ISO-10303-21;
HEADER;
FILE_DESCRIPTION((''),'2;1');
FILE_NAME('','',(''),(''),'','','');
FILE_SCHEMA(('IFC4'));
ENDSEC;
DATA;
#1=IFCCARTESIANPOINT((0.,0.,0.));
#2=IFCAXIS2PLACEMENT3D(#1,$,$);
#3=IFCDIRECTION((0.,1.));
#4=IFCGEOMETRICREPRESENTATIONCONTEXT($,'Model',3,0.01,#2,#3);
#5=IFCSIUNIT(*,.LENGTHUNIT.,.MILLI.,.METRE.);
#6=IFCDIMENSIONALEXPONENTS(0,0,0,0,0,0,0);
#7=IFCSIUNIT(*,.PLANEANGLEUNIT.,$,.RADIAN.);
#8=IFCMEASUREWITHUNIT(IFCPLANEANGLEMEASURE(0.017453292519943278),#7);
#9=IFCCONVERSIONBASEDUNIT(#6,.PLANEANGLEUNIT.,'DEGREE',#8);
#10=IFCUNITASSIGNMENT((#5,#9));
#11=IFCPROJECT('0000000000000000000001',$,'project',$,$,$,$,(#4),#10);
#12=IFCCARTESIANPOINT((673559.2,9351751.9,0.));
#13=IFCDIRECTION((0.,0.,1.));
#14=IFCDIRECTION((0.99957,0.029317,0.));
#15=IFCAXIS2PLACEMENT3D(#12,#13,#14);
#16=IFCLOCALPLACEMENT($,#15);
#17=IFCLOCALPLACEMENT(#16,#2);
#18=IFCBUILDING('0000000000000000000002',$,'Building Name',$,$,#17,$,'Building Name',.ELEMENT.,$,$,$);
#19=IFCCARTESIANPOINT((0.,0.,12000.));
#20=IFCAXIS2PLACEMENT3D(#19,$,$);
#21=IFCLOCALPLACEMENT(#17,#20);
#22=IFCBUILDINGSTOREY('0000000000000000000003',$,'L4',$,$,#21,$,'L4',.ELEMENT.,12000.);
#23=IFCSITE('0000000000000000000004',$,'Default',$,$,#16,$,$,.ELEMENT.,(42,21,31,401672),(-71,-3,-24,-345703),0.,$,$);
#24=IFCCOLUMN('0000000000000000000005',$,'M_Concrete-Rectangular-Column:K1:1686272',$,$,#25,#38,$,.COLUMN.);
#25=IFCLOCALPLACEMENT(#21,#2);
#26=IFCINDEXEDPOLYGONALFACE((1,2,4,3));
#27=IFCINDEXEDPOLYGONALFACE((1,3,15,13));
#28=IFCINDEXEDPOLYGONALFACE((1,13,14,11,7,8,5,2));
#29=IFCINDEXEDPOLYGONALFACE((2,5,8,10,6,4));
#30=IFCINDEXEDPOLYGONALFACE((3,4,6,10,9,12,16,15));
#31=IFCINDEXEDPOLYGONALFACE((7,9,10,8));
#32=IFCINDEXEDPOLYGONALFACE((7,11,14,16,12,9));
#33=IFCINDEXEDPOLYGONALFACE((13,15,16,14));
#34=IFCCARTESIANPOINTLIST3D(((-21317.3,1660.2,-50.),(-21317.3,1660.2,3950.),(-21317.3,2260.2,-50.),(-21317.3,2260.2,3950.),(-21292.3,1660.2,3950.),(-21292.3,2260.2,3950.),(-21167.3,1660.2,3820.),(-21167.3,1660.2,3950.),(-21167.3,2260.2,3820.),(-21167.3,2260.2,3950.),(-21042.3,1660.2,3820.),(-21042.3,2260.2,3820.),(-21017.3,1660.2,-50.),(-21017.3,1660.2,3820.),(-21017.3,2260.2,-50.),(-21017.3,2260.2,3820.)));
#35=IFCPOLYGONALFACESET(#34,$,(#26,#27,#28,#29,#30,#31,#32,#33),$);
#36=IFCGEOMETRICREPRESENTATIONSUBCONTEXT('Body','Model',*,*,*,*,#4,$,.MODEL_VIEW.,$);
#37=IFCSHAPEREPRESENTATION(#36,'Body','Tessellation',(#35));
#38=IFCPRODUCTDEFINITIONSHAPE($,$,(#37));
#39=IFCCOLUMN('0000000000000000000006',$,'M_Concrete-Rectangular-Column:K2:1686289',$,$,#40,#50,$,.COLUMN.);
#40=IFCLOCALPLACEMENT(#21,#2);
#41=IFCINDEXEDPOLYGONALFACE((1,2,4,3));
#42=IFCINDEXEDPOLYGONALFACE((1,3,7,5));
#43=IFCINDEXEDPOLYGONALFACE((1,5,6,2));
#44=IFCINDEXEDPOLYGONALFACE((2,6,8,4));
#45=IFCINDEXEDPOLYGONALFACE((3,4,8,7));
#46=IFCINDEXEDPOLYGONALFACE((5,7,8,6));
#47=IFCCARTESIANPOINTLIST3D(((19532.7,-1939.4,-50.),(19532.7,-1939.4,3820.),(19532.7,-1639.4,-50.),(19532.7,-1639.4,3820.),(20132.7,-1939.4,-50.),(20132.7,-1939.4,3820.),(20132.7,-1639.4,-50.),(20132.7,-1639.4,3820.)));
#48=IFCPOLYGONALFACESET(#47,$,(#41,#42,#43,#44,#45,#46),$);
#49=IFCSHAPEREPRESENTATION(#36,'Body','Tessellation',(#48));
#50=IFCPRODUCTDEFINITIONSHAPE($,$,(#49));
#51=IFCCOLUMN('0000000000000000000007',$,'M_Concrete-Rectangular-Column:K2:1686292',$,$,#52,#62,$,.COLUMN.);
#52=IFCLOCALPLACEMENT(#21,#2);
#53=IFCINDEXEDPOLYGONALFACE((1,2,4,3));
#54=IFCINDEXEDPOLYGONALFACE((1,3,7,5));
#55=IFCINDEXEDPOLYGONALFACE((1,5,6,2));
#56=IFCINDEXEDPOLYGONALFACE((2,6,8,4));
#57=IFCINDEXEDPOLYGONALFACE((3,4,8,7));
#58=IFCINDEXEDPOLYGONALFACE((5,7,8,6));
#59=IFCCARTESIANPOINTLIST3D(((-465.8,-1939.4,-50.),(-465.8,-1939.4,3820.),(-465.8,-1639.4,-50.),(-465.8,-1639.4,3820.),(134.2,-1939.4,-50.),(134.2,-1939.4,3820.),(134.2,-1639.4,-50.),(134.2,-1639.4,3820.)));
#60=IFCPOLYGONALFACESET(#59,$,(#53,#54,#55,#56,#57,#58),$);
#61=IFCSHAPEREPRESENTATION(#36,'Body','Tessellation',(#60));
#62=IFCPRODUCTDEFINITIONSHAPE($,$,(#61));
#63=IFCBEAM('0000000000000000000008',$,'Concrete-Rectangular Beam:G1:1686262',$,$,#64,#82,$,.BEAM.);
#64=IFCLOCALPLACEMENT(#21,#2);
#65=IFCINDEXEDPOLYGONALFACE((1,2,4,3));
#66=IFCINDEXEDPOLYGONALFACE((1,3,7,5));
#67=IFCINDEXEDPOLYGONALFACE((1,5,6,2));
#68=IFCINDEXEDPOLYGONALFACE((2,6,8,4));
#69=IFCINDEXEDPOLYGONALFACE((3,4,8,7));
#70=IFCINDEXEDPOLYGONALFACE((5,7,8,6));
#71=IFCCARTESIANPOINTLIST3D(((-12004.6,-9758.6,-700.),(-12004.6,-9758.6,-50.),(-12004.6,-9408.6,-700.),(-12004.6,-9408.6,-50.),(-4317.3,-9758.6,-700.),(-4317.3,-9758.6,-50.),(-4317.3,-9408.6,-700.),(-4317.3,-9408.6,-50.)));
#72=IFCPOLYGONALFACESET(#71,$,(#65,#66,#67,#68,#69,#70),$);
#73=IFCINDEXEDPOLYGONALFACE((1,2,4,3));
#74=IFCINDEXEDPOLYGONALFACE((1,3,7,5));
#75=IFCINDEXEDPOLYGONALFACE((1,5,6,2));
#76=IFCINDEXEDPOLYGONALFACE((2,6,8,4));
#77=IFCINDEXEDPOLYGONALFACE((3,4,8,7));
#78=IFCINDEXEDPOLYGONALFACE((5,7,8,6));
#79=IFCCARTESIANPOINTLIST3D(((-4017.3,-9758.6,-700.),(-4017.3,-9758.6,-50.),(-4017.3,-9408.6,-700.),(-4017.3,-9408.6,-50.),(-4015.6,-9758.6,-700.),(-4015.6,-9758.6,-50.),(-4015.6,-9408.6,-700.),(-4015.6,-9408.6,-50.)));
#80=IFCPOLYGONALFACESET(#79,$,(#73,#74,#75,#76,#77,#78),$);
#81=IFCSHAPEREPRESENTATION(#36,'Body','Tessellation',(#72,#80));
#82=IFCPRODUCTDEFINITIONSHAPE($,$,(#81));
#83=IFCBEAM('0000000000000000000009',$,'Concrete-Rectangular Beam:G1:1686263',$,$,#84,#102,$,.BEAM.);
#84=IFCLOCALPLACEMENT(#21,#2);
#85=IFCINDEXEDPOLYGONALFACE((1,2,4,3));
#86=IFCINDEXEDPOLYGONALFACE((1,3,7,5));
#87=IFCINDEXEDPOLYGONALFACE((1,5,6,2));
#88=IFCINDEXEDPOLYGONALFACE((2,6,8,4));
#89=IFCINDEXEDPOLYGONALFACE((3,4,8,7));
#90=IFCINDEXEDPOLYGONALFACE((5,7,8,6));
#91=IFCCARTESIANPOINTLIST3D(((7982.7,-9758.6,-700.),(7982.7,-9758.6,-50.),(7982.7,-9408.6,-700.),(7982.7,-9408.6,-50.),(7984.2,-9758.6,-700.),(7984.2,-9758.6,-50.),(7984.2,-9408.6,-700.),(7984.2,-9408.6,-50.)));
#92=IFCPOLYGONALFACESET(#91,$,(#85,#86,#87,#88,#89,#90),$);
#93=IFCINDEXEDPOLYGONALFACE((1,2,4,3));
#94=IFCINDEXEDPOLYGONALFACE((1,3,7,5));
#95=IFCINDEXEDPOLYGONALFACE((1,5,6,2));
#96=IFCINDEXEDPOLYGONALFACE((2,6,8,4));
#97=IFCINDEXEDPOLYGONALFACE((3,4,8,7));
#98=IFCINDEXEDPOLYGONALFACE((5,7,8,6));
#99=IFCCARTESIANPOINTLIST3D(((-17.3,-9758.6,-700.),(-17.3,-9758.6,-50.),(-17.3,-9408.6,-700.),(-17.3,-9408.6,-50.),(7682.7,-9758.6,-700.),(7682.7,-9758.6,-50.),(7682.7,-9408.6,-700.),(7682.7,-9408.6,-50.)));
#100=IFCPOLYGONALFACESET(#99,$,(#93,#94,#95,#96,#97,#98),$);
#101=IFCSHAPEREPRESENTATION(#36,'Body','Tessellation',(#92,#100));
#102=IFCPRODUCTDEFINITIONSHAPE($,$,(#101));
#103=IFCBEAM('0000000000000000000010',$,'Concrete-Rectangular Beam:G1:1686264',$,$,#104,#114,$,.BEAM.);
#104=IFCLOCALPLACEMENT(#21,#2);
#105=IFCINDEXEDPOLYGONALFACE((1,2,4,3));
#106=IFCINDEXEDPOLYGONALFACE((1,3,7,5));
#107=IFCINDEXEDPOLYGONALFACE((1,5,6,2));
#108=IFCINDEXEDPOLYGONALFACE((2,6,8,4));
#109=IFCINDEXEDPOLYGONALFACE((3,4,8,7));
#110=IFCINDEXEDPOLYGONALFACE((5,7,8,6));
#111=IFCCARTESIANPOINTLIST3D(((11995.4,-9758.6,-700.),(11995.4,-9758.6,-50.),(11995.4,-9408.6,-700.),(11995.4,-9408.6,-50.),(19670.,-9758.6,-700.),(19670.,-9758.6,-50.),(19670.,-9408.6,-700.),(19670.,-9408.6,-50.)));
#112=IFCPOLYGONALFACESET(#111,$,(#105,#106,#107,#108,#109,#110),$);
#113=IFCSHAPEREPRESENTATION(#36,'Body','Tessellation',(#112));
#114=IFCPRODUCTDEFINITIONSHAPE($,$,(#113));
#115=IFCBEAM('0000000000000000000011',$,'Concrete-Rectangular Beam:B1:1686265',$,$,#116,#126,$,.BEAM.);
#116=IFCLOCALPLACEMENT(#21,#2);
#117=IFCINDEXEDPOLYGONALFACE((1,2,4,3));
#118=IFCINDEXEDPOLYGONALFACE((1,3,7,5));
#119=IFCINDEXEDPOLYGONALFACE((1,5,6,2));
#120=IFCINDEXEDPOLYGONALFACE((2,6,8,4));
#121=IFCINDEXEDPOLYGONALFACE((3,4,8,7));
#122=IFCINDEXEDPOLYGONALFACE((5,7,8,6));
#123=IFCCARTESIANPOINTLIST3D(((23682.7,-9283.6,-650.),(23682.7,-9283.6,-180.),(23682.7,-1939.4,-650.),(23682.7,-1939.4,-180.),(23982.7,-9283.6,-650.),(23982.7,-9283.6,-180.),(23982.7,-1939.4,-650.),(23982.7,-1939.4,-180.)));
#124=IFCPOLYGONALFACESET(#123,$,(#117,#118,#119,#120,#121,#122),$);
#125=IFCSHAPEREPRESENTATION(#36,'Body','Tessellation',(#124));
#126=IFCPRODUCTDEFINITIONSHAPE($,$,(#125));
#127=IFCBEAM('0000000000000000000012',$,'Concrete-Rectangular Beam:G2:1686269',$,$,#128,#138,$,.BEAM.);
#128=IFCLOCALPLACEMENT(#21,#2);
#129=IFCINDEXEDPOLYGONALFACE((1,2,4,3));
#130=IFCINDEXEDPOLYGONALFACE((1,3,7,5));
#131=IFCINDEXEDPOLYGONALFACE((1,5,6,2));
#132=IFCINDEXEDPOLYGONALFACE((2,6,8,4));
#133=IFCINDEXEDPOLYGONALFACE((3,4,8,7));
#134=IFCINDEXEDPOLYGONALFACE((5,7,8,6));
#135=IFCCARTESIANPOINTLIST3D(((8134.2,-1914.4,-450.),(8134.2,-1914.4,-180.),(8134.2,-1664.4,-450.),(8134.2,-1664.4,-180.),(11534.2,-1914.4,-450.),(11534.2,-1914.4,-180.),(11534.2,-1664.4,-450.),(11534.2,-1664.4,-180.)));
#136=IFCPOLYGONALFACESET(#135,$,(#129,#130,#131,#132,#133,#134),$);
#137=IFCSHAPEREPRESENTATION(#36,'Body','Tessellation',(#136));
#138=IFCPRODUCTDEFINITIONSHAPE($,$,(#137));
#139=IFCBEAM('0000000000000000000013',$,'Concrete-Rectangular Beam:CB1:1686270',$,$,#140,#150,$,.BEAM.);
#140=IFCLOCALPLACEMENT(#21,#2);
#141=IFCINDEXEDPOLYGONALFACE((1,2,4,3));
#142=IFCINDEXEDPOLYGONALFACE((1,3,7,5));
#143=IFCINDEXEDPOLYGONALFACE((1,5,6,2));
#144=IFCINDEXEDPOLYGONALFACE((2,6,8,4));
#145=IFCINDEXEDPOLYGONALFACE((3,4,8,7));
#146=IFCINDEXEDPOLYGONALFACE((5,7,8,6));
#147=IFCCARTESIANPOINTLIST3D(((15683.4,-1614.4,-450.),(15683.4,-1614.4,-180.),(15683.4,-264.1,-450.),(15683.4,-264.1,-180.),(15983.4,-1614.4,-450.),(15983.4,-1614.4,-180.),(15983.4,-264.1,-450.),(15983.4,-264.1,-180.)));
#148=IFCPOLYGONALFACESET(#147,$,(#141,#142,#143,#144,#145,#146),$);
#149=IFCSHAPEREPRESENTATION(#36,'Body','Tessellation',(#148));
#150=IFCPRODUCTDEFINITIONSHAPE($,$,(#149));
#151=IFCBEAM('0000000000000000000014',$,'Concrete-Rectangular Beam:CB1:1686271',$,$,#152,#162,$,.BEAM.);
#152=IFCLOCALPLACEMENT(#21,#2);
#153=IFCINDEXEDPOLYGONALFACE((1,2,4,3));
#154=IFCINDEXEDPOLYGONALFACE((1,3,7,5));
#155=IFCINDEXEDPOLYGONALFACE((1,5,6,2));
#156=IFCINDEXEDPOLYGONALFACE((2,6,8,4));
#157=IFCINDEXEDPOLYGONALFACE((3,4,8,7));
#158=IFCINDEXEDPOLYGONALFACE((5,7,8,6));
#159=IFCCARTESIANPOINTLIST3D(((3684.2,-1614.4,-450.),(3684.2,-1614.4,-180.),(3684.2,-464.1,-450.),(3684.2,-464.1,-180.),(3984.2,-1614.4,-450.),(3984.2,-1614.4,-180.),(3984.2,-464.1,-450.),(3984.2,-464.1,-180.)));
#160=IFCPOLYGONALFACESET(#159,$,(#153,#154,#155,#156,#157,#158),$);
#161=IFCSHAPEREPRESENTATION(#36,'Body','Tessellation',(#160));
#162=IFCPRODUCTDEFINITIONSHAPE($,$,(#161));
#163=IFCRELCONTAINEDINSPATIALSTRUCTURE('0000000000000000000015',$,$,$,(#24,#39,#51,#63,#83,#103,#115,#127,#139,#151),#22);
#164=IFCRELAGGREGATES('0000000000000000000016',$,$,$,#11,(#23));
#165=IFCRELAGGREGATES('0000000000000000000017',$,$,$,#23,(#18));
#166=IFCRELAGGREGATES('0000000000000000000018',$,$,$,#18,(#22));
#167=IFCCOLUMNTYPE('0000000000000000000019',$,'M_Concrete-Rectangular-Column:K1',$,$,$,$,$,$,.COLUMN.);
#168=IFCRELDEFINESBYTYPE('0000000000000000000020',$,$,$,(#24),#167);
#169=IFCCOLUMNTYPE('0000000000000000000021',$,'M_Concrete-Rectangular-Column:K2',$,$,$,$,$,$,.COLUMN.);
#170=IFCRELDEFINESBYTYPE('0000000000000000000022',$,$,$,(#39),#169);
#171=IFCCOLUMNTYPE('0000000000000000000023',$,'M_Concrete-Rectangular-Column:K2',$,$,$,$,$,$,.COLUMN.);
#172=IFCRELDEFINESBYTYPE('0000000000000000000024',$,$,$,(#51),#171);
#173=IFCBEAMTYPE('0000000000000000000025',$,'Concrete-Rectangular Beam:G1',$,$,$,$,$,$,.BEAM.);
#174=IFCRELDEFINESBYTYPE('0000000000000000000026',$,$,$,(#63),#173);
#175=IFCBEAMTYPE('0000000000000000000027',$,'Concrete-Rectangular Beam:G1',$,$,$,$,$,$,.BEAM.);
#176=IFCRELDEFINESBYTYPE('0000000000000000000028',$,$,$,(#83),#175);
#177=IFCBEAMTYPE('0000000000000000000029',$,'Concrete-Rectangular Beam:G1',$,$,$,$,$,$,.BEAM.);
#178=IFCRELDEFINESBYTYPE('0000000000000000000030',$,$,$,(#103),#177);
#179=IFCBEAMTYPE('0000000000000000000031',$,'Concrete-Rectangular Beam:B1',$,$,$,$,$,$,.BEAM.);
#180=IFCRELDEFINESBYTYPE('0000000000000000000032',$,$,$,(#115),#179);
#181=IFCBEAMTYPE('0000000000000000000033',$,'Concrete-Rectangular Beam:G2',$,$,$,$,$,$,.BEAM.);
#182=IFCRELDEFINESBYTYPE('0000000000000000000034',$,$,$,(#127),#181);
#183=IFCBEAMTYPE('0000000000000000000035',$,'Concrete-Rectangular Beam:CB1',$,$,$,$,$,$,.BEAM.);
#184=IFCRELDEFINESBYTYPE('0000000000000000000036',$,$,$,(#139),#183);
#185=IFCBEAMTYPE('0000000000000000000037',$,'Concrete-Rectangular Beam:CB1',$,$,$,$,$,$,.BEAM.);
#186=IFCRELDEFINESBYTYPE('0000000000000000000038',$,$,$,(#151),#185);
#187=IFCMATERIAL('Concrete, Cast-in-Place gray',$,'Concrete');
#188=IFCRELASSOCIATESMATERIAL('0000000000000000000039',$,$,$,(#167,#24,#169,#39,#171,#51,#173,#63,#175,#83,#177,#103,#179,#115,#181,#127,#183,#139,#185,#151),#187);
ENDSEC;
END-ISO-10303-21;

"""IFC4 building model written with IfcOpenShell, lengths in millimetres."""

from ifc_helpers import new_model, entity, si_unit, converted_unit, direction, frame, origin, place, context, subcontext, project, spatial, indexed_curve, outline, extrude, source, transform, mapped, material, type_object, type_shapes, element, save


model = new_model("IFC4")

# Units and contexts
model_context = context("Model", 3, precision=0.01, world=origin(), true_north=direction((0.0, 1.0)))
body_context = subcontext(model_context, "Body", "Model", "MODEL_VIEW")
ifc_project = project(units=[si_unit("LENGTHUNIT", "METRE", prefix="MILLI"), converted_unit("PLANEANGLEUNIT", "DEGREE", entity("IfcPlaneAngleMeasure", 0.017453292519943278), si_unit("PLANEANGLEUNIT", "RADIAN"), dimensions=[0, 0, 0, 0, 0, 0, 0])], contexts=[model_context])

# Site, building, storey
site_placement = place(None, frame((673559.2, 9351751.9, 0.0), z_axis=(0.0, 0.0, 1.0), x_axis=(0.99957, 0.029317, 0.0)))
site = spatial("IfcSite", under=ifc_project, at=site_placement, Name="Default", CompositionType="ELEMENT", RefLatitude=(42, 21, 31, 401672), RefLongitude=(-71, -3, -24, -345703), RefElevation=0.0)
building_placement = place(site_placement, origin())
building = spatial("IfcBuilding", under=site, at=building_placement, Name="Building Name", LongName="Building Name", CompositionType="ELEMENT")
storey_placement = place(building_placement, frame((0.0, 0.0, 12000.0)))
storey = spatial("IfcBuildingStorey", under=building, at=storey_placement, Name="L4", LongName="L4", CompositionType="ELEMENT", Elevation=12000.0)

# Columns
ifc_material = material(Name="Concrete, Cast-in-Place gray", Category="Concrete")
column_type_1 = type_object("IfcColumnType", Name="M_Concrete-Rectangular-Column:K1", PredefinedType="COLUMN", material=ifc_material)
shared_shape_1 = source(origin(), body_context, "Body", "SweptSolid", [
    extrude(outline(indexed_curve([(-2951.3, -150.0), (1048.7, -150.0), (1048.7, -125.0), (1048.7, 0.0), (918.7, 0.0), (918.7, 125.0), (918.7, 150.0), (-2951.3, 150.0), (-2951.3, -150.0)], self_intersect=False)), frame((-21167.3, 1660.2, 14901.3), z_axis=(0.0, 1.0, 0.0), x_axis=(0.0, 0.0, 1.0)), (0.0, 0.0, 1.0), 600.0),
])
type_shapes(column_type_1, [shared_shape_1])
column_1_placement = place(storey_placement, frame((0.0, 0.0, -12000.0)))
element("IfcColumn", 1, at=column_1_placement, inside=storey, type_object=column_type_1, material=ifc_material, Name="M_Concrete-Rectangular-Column:K1:1686272", PredefinedType="COLUMN", context=body_context, shape_type="MappedRepresentation", body=[
    mapped(shared_shape_1, transform((0.0, 0.0, 0.0), scale=1.0)),
])
column_type_2 = type_object("IfcColumnType", Name="M_Concrete-Rectangular-Column:K2", PredefinedType="COLUMN", material=ifc_material)
shared_shape_2 = source(origin(), body_context, "Body", "SweptSolid", [
    extrude(outline(indexed_curve([(-150.0, -300.0), (150.0, -300.0), (150.0, 300.0), (-150.0, 300.0), (-150.0, -300.0)], self_intersect=False)), frame((19832.7, -1789.4, 11950.0), z_axis=(0.0, 0.0, 1.0), x_axis=(0.0, -1.0, 0.0)), (0.0, 0.0, 1.0), 3870.0),
])
type_shapes(column_type_2, [shared_shape_2])
column_2_placement = place(storey_placement, frame((0.0, 0.0, -12000.0)))
element("IfcColumn", 2, at=column_2_placement, inside=storey, type_object=column_type_2, material=ifc_material, Name="M_Concrete-Rectangular-Column:K2:1686289", PredefinedType="COLUMN", context=body_context, shape_type="MappedRepresentation", body=[
    mapped(shared_shape_2, transform((0.0, 0.0, 0.0), scale=1.0)),
])
column_type_3 = type_object("IfcColumnType", Name="M_Concrete-Rectangular-Column:K2", PredefinedType="COLUMN", material=ifc_material)
shared_shape_3 = source(origin(), body_context, "Body", "SweptSolid", [
    extrude(outline(indexed_curve([(-150.0, -300.0), (150.0, -300.0), (150.0, 300.0), (-150.0, 300.0), (-150.0, -300.0)], self_intersect=False)), frame((-165.8, -1789.4, 11950.0), z_axis=(0.0, 0.0, 1.0), x_axis=(0.0, -1.0, 0.0)), (0.0, 0.0, 1.0), 3870.0),
])
type_shapes(column_type_3, [shared_shape_3])
column_3_placement = place(storey_placement, frame((0.0, 0.0, -12000.0)))
element("IfcColumn", 3, at=column_3_placement, inside=storey, type_object=column_type_3, material=ifc_material, Name="M_Concrete-Rectangular-Column:K2:1686292", PredefinedType="COLUMN", context=body_context, shape_type="MappedRepresentation", body=[
    mapped(shared_shape_3, transform((0.0, 0.0, 0.0), scale=1.0)),
])

# Beams
beam_type_1 = type_object("IfcBeamType", Name="Concrete-Rectangular Beam:G1", PredefinedType="BEAM", material=ifc_material)
shared_shape_4 = source(origin(), body_context, "Body", "SweptSolid", [
    extrude(outline(indexed_curve([(-325.0, -175.0), (325.0, -175.0), (325.0, 175.0), (-325.0, 175.0), (-325.0, -175.0)], self_intersect=False)), frame((-12004.6, -9583.6, 11625.0), z_axis=(1.0, 0.0, 0.0), x_axis=(0.0, 0.0, -1.0)), (0.0, 0.0, 1.0), 7687.3),
    extrude(outline(indexed_curve([(-325.0, -175.0), (325.0, -175.0), (325.0, 175.0), (-325.0, 175.0), (-325.0, -175.0)], self_intersect=False)), frame((-4017.3, -9583.6, 11625.0), z_axis=(1.0, 0.0, 0.0), x_axis=(0.0, 0.0, -1.0)), (0.0, 0.0, 1.0), 1.8),
])
type_shapes(beam_type_1, [shared_shape_4])
beam_1_placement = place(storey_placement, frame((0.0, 0.0, -12000.0)))
element("IfcBeam", 4, at=beam_1_placement, inside=storey, type_object=beam_type_1, material=ifc_material, Name="Concrete-Rectangular Beam:G1:1686262", PredefinedType="BEAM", context=body_context, shape_type="MappedRepresentation", body=[
    mapped(shared_shape_4, transform((0.0, 0.0, 0.0), scale=1.0)),
])
beam_type_2 = type_object("IfcBeamType", Name="Concrete-Rectangular Beam:G1", PredefinedType="BEAM", material=ifc_material)
shared_shape_5 = source(origin(), body_context, "Body", "SweptSolid", [
    extrude(outline(indexed_curve([(-325.0, -175.0), (325.0, -175.0), (325.0, 175.0), (-325.0, 175.0), (-325.0, -175.0)], self_intersect=False)), frame((7982.7, -9583.6, 11625.0), z_axis=(1.0, 0.0, 0.0), x_axis=(0.0, 0.0, -1.0)), (0.0, 0.0, 1.0), 1.5),
    extrude(outline(indexed_curve([(-325.0, -175.0), (325.0, -175.0), (325.0, 175.0), (-325.0, 175.0), (-325.0, -175.0)], self_intersect=False)), frame((-17.3, -9583.6, 11625.0), z_axis=(1.0, 0.0, 0.0), x_axis=(0.0, 0.0, -1.0)), (0.0, 0.0, 1.0), 7700.0),
])
type_shapes(beam_type_2, [shared_shape_5])
beam_2_placement = place(storey_placement, frame((0.0, 0.0, -12000.0)))
element("IfcBeam", 5, at=beam_2_placement, inside=storey, type_object=beam_type_2, material=ifc_material, Name="Concrete-Rectangular Beam:G1:1686263", PredefinedType="BEAM", context=body_context, shape_type="MappedRepresentation", body=[
    mapped(shared_shape_5, transform((0.0, 0.0, 0.0), scale=1.0)),
])
beam_type_3 = type_object("IfcBeamType", Name="Concrete-Rectangular Beam:G1", PredefinedType="BEAM", material=ifc_material)
shared_shape_6 = source(origin(), body_context, "Body", "SweptSolid", [
    extrude(outline(indexed_curve([(-325.0, -175.0), (325.0, -175.0), (325.0, 175.0), (-325.0, 175.0), (-325.0, -175.0)], self_intersect=False)), frame((11995.4, -9583.6, 11625.0), z_axis=(1.0, 0.0, 0.0), x_axis=(0.0, 0.0, -1.0)), (0.0, 0.0, 1.0), 7674.6),
])
type_shapes(beam_type_3, [shared_shape_6])
beam_3_placement = place(storey_placement, frame((0.0, 0.0, -12000.0)))
element("IfcBeam", 6, at=beam_3_placement, inside=storey, type_object=beam_type_3, material=ifc_material, Name="Concrete-Rectangular Beam:G1:1686264", PredefinedType="BEAM", context=body_context, shape_type="MappedRepresentation", body=[
    mapped(shared_shape_6, transform((0.0, 0.0, 0.0), scale=1.0)),
])
beam_type_4 = type_object("IfcBeamType", Name="Concrete-Rectangular Beam:B1", PredefinedType="BEAM", material=ifc_material)
shared_shape_7 = source(origin(), body_context, "Body", "SweptSolid", [
    extrude(outline(indexed_curve([(-150.0, -235.0), (150.0, -235.0), (150.0, 235.0), (-150.0, 235.0), (-150.0, -235.0)], self_intersect=False)), frame((23832.7, -9283.6, 11585.0), z_axis=(0.0, 1.0, 0.0), x_axis=(-1.0, 0.0, 0.0)), (0.0, 0.0, 1.0), 7344.1),
])
type_shapes(beam_type_4, [shared_shape_7])
beam_4_placement = place(storey_placement, frame((0.0, 0.0, -12000.0)))
element("IfcBeam", 7, at=beam_4_placement, inside=storey, type_object=beam_type_4, material=ifc_material, Name="Concrete-Rectangular Beam:B1:1686265", PredefinedType="BEAM", context=body_context, shape_type="MappedRepresentation", body=[
    mapped(shared_shape_7, transform((0.0, 0.0, 0.0), scale=1.0)),
])
beam_type_5 = type_object("IfcBeamType", Name="Concrete-Rectangular Beam:G2", PredefinedType="BEAM", material=ifc_material)
shared_shape_8 = source(origin(), body_context, "Body", "SweptSolid", [
    extrude(outline(indexed_curve([(-135.0, -125.0), (135.0, -125.0), (135.0, 125.0), (-135.0, 125.0), (-135.0, -125.0)], self_intersect=False)), frame((8134.2, -1789.4, 11685.0), z_axis=(1.0, 0.0, 0.0), x_axis=(0.0, 0.0, -1.0)), (0.0, 0.0, 1.0), 3400.0),
])
type_shapes(beam_type_5, [shared_shape_8])
beam_5_placement = place(storey_placement, frame((0.0, 0.0, -12000.0)))
element("IfcBeam", 8, at=beam_5_placement, inside=storey, type_object=beam_type_5, material=ifc_material, Name="Concrete-Rectangular Beam:G2:1686269", PredefinedType="BEAM", context=body_context, shape_type="MappedRepresentation", body=[
    mapped(shared_shape_8, transform((0.0, 0.0, 0.0), scale=1.0)),
])
beam_type_6 = type_object("IfcBeamType", Name="Concrete-Rectangular Beam:CB1", PredefinedType="BEAM", material=ifc_material)
shared_shape_9 = source(origin(), body_context, "Body", "SweptSolid", [
    extrude(outline(indexed_curve([(-150.0, -135.0), (150.0, -135.0), (150.0, 135.0), (-150.0, 135.0), (-150.0, -135.0)], self_intersect=False)), frame((15833.4, -1614.4, 11685.0), z_axis=(0.0, 1.0, 0.0), x_axis=(-1.0, 0.0, 0.0)), (0.0, 0.0, 1.0), 1350.4),
])
type_shapes(beam_type_6, [shared_shape_9])
beam_6_placement = place(storey_placement, frame((0.0, 0.0, -12000.0)))
element("IfcBeam", 9, at=beam_6_placement, inside=storey, type_object=beam_type_6, material=ifc_material, Name="Concrete-Rectangular Beam:CB1:1686270", PredefinedType="BEAM", context=body_context, shape_type="MappedRepresentation", body=[
    mapped(shared_shape_9, transform((0.0, 0.0, 0.0), scale=1.0)),
])
beam_type_7 = type_object("IfcBeamType", Name="Concrete-Rectangular Beam:CB1", PredefinedType="BEAM", material=ifc_material)
shared_shape_10 = source(origin(), body_context, "Body", "SweptSolid", [
    extrude(outline(indexed_curve([(-150.0, -135.0), (150.0, -135.0), (150.0, 135.0), (-150.0, 135.0), (-150.0, -135.0)], self_intersect=False)), frame((3834.2, -1614.4, 11685.0), z_axis=(0.0, 1.0, 0.0), x_axis=(-1.0, 0.0, 0.0)), (0.0, 0.0, 1.0), 1150.4),
])
type_shapes(beam_type_7, [shared_shape_10])
beam_7_placement = place(storey_placement, frame((0.0, 0.0, -12000.0)))
element("IfcBeam", 10, at=beam_7_placement, inside=storey, type_object=beam_type_7, material=ifc_material, Name="Concrete-Rectangular Beam:CB1:1686271", PredefinedType="BEAM", context=body_context, shape_type="MappedRepresentation", body=[
    mapped(shared_shape_10, transform((0.0, 0.0, 0.0), scale=1.0)),
])

save(model, "model.ifc")
